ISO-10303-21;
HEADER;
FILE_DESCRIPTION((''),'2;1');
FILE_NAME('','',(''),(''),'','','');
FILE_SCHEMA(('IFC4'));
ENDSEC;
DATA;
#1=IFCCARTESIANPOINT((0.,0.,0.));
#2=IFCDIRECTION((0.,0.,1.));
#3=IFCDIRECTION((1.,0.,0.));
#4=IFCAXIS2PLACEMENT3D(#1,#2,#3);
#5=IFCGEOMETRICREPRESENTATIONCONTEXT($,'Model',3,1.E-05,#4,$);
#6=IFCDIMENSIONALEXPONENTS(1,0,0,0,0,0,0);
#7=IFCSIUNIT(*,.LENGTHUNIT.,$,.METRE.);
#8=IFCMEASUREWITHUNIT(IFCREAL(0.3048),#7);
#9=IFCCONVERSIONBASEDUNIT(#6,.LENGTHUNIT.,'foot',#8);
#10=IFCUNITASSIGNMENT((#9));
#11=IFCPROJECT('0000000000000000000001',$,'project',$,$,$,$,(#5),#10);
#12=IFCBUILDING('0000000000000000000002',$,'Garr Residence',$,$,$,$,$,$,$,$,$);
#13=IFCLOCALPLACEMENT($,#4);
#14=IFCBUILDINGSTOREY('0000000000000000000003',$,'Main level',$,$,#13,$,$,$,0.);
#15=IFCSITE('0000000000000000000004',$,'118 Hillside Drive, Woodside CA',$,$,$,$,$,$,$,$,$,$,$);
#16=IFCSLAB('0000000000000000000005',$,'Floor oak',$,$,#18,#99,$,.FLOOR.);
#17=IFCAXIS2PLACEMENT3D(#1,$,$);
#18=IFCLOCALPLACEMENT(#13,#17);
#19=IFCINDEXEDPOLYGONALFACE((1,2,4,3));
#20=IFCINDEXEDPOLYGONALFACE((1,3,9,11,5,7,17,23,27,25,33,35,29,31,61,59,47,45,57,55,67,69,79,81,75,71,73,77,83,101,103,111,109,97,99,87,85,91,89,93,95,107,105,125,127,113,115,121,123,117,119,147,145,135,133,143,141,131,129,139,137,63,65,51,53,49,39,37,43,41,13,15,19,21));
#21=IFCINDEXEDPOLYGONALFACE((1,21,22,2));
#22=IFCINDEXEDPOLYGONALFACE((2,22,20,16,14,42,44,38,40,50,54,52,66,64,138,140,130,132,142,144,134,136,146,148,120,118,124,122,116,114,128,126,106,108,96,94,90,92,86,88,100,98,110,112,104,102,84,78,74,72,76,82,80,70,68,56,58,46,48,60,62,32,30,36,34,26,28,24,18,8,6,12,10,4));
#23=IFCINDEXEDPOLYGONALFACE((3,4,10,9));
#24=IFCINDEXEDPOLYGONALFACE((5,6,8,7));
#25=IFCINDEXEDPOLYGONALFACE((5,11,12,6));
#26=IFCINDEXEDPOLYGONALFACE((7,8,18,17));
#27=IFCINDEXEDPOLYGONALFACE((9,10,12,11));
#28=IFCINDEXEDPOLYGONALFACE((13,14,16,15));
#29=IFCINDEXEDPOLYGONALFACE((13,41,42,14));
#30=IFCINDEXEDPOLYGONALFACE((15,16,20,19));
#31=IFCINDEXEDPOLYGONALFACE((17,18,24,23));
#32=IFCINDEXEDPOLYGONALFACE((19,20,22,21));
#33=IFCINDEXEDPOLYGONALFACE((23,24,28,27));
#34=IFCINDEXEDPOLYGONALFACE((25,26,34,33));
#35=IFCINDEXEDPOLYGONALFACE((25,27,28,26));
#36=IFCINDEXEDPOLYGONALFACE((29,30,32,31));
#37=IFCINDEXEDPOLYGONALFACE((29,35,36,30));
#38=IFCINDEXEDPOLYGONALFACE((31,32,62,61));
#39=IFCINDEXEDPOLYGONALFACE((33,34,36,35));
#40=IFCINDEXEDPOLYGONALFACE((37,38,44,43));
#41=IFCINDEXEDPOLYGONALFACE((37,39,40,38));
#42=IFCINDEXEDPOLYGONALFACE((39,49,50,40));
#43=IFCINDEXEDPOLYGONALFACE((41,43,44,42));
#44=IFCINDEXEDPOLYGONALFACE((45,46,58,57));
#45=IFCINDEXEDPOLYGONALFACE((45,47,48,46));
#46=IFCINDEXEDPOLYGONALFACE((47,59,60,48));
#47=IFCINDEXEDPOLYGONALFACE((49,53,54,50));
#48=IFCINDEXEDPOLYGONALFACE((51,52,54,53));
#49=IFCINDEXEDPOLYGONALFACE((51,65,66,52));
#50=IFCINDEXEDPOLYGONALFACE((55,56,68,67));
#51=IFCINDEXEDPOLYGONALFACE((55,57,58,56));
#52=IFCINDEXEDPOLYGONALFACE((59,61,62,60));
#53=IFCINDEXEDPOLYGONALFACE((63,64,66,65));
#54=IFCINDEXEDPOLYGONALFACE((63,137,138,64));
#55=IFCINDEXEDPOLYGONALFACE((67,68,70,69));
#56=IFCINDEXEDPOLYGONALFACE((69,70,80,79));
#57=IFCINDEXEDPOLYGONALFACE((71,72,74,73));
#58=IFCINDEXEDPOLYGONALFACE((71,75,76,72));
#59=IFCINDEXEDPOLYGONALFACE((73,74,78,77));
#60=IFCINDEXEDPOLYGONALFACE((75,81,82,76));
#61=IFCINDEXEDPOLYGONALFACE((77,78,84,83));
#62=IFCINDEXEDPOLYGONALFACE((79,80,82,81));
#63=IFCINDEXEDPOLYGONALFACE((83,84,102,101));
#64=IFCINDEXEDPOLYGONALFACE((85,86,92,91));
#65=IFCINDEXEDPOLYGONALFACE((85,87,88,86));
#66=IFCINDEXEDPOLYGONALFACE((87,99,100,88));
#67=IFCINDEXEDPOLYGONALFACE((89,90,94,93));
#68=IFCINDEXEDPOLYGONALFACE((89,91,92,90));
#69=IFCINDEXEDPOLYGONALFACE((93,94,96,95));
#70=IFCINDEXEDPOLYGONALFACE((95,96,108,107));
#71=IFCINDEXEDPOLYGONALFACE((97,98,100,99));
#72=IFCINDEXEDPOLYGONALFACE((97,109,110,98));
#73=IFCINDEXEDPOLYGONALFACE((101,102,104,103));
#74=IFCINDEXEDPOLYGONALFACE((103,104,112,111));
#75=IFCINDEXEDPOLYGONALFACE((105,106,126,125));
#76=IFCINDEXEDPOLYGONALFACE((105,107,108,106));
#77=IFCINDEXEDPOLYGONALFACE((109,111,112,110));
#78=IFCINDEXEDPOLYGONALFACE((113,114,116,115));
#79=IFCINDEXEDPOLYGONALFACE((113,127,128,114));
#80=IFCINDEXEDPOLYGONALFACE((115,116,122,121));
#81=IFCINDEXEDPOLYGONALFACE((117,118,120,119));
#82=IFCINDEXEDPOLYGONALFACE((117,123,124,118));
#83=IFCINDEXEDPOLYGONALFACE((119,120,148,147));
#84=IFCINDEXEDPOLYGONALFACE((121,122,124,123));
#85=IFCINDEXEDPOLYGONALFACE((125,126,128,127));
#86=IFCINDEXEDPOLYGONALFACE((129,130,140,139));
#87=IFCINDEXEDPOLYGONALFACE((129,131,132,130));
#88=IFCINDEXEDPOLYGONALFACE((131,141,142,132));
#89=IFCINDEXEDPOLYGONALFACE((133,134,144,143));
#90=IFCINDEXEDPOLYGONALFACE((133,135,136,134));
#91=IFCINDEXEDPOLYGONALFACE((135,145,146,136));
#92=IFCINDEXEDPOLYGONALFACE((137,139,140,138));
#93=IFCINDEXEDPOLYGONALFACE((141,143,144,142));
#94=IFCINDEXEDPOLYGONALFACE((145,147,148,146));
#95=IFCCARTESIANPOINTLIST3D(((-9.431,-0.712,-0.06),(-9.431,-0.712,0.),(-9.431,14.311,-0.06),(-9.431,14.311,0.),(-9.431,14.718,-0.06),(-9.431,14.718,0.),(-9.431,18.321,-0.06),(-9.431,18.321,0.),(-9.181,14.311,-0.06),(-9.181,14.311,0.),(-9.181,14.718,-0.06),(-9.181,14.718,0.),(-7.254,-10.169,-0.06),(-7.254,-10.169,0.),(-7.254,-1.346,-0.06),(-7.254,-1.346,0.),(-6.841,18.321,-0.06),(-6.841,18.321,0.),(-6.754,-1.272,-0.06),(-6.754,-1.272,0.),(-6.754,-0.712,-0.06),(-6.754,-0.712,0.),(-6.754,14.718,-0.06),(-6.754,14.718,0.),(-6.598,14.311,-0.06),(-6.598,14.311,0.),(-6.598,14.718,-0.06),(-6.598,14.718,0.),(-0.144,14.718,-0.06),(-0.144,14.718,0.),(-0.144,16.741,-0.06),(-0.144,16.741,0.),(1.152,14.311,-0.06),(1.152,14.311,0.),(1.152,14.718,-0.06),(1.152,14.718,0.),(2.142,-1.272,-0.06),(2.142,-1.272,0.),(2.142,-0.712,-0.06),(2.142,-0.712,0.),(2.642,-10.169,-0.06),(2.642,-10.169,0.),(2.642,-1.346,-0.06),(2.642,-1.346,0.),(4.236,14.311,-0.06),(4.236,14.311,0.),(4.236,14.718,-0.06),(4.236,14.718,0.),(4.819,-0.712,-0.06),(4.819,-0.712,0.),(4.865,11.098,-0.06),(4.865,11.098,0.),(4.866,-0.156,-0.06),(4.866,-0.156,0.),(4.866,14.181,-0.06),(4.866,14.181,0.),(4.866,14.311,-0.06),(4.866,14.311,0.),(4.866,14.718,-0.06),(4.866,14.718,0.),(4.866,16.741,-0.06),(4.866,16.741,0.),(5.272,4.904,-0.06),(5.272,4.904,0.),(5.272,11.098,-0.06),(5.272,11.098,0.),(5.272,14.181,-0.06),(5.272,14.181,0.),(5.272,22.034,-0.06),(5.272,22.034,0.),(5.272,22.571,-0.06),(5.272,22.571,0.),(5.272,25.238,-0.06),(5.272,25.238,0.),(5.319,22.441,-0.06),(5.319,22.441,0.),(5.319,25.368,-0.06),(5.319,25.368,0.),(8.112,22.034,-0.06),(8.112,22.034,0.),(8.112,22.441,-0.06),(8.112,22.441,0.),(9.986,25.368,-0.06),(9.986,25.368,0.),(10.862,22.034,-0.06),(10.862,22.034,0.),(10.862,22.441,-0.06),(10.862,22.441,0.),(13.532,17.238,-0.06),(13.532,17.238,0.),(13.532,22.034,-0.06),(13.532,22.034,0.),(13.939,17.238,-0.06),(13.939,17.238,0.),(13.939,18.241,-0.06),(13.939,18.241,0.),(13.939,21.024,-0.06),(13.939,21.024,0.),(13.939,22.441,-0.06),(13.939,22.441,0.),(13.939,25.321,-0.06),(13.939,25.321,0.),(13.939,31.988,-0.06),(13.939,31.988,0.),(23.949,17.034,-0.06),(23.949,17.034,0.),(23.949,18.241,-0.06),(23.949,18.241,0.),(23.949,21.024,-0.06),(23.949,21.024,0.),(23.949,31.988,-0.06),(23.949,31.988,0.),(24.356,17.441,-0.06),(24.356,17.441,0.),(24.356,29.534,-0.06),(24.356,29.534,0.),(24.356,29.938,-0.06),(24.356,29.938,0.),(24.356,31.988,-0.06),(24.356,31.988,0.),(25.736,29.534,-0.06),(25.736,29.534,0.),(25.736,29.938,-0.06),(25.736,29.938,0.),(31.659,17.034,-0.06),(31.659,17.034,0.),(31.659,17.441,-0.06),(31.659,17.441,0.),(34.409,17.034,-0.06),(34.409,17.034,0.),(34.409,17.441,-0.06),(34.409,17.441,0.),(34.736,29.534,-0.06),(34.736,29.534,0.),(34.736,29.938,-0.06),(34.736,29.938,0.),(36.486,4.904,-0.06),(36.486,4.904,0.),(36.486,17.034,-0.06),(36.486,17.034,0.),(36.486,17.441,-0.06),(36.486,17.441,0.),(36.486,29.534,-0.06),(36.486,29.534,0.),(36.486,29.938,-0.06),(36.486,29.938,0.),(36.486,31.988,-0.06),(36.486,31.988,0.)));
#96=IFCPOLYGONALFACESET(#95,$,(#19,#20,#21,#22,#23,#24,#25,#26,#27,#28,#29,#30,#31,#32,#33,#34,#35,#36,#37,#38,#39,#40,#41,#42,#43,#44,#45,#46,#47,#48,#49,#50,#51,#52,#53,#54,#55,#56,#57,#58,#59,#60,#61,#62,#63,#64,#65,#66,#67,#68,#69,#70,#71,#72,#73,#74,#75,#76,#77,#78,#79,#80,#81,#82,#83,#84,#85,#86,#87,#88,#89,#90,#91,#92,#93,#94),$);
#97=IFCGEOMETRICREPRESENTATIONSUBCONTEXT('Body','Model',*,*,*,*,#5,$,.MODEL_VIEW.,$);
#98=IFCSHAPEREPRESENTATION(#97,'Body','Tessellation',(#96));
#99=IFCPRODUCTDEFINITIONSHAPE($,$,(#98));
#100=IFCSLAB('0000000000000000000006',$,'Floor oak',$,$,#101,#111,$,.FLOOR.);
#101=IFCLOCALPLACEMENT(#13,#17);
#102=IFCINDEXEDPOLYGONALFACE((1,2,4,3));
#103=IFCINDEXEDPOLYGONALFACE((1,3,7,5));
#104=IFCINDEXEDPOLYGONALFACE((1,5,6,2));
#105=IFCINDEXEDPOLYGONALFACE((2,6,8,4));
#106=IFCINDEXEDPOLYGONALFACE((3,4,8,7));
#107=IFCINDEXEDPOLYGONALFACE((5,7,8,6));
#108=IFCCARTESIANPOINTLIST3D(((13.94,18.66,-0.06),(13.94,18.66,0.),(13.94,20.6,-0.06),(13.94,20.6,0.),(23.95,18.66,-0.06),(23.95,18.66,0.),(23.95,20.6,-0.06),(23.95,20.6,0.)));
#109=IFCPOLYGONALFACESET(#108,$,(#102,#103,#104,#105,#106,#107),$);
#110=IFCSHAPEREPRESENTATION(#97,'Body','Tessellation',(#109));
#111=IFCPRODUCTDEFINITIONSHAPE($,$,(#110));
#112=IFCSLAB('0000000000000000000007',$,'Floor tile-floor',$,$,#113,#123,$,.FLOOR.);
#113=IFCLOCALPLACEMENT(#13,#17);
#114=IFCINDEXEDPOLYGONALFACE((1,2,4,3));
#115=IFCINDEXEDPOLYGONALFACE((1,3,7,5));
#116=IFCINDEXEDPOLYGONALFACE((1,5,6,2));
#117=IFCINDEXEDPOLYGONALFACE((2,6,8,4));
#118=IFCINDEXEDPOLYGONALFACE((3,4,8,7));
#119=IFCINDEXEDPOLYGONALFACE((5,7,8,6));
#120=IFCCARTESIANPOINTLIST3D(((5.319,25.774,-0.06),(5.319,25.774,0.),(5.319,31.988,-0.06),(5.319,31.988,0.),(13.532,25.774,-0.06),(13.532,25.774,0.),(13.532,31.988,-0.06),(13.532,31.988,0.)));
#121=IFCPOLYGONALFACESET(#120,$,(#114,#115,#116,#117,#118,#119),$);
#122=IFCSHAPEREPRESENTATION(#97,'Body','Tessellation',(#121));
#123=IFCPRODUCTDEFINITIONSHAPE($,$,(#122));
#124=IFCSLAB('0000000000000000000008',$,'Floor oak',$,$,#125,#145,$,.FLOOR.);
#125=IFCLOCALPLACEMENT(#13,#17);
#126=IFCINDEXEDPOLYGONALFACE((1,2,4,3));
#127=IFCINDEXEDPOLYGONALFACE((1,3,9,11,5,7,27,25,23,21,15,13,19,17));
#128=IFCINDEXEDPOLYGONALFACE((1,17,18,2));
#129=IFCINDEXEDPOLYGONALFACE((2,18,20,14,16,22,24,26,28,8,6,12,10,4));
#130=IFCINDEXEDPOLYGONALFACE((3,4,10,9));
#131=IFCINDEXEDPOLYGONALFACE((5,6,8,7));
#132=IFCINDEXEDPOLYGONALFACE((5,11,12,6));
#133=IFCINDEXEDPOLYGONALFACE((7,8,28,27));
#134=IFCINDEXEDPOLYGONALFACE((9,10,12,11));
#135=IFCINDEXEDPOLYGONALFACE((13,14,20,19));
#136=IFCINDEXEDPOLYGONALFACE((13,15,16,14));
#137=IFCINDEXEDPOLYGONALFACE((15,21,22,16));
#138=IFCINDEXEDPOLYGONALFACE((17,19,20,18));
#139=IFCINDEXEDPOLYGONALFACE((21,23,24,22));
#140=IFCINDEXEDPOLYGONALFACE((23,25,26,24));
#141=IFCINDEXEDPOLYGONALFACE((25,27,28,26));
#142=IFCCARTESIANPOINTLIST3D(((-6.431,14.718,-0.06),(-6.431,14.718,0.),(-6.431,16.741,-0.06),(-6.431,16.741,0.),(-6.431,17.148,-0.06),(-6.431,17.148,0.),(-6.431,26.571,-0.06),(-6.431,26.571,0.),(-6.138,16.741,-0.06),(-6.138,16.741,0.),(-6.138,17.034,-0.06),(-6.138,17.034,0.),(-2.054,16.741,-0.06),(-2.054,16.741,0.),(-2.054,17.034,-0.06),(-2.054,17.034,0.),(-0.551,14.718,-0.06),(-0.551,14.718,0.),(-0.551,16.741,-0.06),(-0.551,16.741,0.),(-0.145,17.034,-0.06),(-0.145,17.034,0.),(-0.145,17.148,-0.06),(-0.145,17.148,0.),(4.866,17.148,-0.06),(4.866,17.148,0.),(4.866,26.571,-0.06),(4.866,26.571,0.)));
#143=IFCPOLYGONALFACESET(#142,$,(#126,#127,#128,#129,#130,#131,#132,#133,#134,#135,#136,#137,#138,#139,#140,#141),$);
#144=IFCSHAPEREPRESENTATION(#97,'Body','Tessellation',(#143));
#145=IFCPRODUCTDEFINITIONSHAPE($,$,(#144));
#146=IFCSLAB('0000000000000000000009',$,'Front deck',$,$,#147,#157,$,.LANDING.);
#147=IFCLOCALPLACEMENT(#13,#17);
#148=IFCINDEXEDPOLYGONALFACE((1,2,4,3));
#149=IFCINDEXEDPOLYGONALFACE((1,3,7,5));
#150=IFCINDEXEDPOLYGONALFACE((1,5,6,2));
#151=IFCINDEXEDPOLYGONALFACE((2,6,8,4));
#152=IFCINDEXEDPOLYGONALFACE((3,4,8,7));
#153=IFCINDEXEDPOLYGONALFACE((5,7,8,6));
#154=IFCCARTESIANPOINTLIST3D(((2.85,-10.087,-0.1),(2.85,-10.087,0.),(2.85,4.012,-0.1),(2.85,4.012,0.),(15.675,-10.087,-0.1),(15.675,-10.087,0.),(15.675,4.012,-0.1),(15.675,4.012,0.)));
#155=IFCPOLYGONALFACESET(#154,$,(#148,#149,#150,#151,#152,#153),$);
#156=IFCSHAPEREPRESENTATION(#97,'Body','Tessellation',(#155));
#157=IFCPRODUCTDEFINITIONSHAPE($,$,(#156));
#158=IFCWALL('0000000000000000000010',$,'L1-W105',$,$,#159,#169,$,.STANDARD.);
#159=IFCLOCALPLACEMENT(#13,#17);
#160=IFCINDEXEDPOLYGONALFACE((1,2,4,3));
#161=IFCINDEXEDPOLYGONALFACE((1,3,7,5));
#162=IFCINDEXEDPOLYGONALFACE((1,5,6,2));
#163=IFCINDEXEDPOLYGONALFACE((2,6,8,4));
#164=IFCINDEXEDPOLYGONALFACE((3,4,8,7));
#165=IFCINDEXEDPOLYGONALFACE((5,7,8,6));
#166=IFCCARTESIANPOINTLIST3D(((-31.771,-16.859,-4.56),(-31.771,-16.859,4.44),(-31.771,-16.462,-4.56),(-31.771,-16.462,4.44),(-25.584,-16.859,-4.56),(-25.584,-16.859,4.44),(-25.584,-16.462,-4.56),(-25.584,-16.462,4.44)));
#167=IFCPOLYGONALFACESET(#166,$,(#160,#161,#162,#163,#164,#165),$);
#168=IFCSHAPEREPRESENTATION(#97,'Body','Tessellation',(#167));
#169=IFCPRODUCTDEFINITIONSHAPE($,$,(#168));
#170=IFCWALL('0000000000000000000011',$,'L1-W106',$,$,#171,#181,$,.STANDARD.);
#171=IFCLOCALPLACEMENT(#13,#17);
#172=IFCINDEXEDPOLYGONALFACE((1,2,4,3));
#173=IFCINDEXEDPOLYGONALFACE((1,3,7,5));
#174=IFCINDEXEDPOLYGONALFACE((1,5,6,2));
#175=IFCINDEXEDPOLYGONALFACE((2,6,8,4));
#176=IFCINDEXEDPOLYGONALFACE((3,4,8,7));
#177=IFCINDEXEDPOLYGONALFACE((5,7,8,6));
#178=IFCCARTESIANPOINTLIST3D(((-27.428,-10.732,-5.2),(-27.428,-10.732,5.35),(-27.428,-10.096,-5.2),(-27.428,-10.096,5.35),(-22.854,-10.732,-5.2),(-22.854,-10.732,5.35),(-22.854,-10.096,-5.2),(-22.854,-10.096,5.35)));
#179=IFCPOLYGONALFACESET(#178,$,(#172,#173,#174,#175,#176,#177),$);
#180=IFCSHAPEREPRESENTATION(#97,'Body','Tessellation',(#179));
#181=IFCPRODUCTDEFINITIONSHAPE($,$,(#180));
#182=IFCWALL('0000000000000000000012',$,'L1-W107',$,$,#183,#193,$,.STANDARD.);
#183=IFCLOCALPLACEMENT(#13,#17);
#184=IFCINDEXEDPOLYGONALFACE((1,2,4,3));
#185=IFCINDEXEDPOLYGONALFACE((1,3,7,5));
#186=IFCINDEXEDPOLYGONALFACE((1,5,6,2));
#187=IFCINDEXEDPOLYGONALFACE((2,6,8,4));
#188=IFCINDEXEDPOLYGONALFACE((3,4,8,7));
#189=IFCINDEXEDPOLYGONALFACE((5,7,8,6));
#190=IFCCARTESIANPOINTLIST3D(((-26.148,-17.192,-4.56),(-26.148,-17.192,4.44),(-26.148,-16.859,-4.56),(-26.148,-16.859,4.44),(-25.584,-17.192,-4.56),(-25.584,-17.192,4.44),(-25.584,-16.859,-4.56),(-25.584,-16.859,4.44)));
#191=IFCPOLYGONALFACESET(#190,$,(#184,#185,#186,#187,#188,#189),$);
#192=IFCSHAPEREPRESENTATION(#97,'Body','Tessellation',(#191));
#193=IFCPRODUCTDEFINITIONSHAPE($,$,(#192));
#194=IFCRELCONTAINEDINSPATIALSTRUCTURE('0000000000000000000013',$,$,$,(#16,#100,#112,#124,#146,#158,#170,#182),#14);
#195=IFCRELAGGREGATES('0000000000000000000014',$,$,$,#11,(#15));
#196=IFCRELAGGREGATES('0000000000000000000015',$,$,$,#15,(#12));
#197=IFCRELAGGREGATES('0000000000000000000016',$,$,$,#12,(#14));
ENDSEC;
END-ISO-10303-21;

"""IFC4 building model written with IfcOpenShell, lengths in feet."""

from ifc_helpers import new_model, entity, si_unit, converted_unit, frame, origin, origin_with_axes, place, context, subcontext, project, spatial, polyline, outline, extrude, element, save


model = new_model("IFC4")

# Units and contexts
model_context = context("Model", 3, precision=1e-05, world=origin_with_axes())
body_context = subcontext(model_context, "Body", "Model", "MODEL_VIEW")
ifc_project = project(units=[converted_unit("LENGTHUNIT", "foot", entity("IfcReal", 0.3048), si_unit("LENGTHUNIT", "METRE"), dimensions=[1, 0, 0, 0, 0, 0, 0])], contexts=[model_context])

# Site, building, storey
site = spatial("IfcSite", under=ifc_project, Name="118 Hillside Drive, Woodside CA")
building = spatial("IfcBuilding", under=site, Name="Garr Residence")
storey_placement = place(None, origin_with_axes())
storey = spatial("IfcBuildingStorey", under=building, at=storey_placement, Name="Main level", Elevation=0.0)

# Slabs
slab_1_placement = place(storey_placement, frame((0.0, 0.0, -0.06), z_axis=(0.0, 0.0, 1.0), x_axis=(1.0, 0.0, 0.0)))
element("IfcSlab", 1, at=slab_1_placement, inside=storey, Name="Floor oak", PredefinedType="FLOOR", context=body_context, shape_type="SweptSolid", body=[
    extrude(outline(polyline([(-9.431, 18.321), (-6.841, 18.321), (-6.754, 14.718), (-6.598, 14.718), (-6.598, 14.311), (1.152, 14.311), (1.152, 14.718), (-0.144, 14.718), (-0.144, 16.741), (4.866, 16.741), (4.866, 14.718), (4.236, 14.718), (4.236, 14.311), (4.866, 14.311), (4.866, 14.181), (5.272, 14.181), (5.272, 22.034), (8.112, 22.034), (8.112, 22.441), (5.319, 22.441), (5.272, 22.571), (5.272, 25.238), (5.319, 25.368), (9.986, 25.368), (13.939, 25.321), (13.939, 31.988), (23.949, 31.988), (23.949, 21.024), (13.939, 21.024), (13.939, 22.441), (10.862, 22.441), (10.862, 22.034), (13.532, 22.034), (13.532, 17.238), (13.939, 17.238), (13.939, 18.241), (23.949, 18.241), (23.949, 17.034), (31.659, 17.034), (31.659, 17.441), (24.356, 17.441), (24.356, 29.534), (25.736, 29.534), (25.736, 29.938), (24.356, 29.938), (24.356, 31.988), (36.486, 31.988), (36.486, 29.938), (34.736, 29.938), (34.736, 29.534), (36.486, 29.534), (36.486, 17.441), (34.409, 17.441), (34.409, 17.034), (36.486, 17.034), (36.486, 4.904), (5.272, 4.904), (5.272, 11.098), (4.865, 11.098), (4.866, -0.156), (4.819, -0.712), (2.142, -0.712), (2.142, -1.272), (2.642, -1.346), (2.642, -10.169), (-7.254, -10.169), (-7.254, -1.346), (-6.754, -1.272), (-6.754, -0.712), (-9.431, -0.712), (-9.431, 14.311), (-9.181, 14.311), (-9.181, 14.718), (-9.431, 14.718), (-9.431, 18.321)])), origin(), (0.0, 0.0, 1.0), 0.06),
])
slab_2_placement = place(storey_placement, frame((0.0, 0.0, -0.06), z_axis=(0.0, 0.0, 1.0), x_axis=(1.0, 0.0, 0.0)))
element("IfcSlab", 2, at=slab_2_placement, inside=storey, Name="Floor oak", PredefinedType="FLOOR", context=body_context, shape_type="SweptSolid", body=[
    extrude(outline(polyline([(23.95, 20.6), (23.95, 18.66), (13.94, 18.66), (13.94, 20.6), (23.95, 20.6)])), origin(), (0.0, 0.0, 1.0), 0.06),
])
slab_3_placement = place(storey_placement, frame((0.0, 0.0, -0.06), z_axis=(0.0, 0.0, 1.0), x_axis=(1.0, 0.0, 0.0)))
element("IfcSlab", 3, at=slab_3_placement, inside=storey, Name="Floor tile-floor", PredefinedType="FLOOR", context=body_context, shape_type="SweptSolid", body=[
    extrude(outline(polyline([(5.319, 25.774), (5.319, 31.988), (13.532, 31.988), (13.532, 25.774), (5.319, 25.774)])), origin(), (0.0, 0.0, 1.0), 0.06),
])
slab_4_placement = place(storey_placement, frame((0.0, 0.0, -0.06), z_axis=(0.0, 0.0, 1.0), x_axis=(1.0, 0.0, 0.0)))
element("IfcSlab", 4, at=slab_4_placement, inside=storey, Name="Floor oak", PredefinedType="FLOOR", context=body_context, shape_type="SweptSolid", body=[
    extrude(outline(polyline([(-6.138, 16.741), (-6.138, 17.034), (-6.431, 17.148), (-6.431, 26.571), (4.866, 26.571), (4.866, 17.148), (-0.145, 17.148), (-0.145, 17.034), (-2.054, 17.034), (-2.054, 16.741), (-0.551, 16.741), (-0.551, 14.718), (-6.431, 14.718), (-6.431, 16.741), (-6.138, 16.741)])), origin(), (0.0, 0.0, 1.0), 0.06),
])
slab_5_placement = place(storey_placement, frame((0.0, 0.0, -0.1), z_axis=(0.0, 0.0, 1.0), x_axis=(1.0, 0.0, 0.0)))
element("IfcSlab", 5, at=slab_5_placement, inside=storey, Name="Front deck", PredefinedType="LANDING", context=body_context, shape_type="SweptSolid", body=[
    extrude(outline(polyline([(2.85, -10.087), (15.675, -10.087), (15.675, 4.012), (2.85, 4.012), (2.85, -10.087)])), origin(), (0.0, 0.0, 1.0), 0.1),
])

# Walls
wall_1_placement = place(storey_placement, frame((0.0, 0.0, -4.56), z_axis=(0.0, 0.0, 1.0), x_axis=(1.0, 0.0, 0.0)))
element("IfcWall", 6, at=wall_1_placement, inside=storey, Name="L1-W105", PredefinedType="STANDARD", context=body_context, shape_type="SweptSolid", body=[
    extrude(outline(polyline([(-25.584, -16.859), (-25.584, -16.462), (-31.771, -16.462), (-31.771, -16.859), (-25.584, -16.859)])), origin(), (0.0, 0.0, 1.0), 9.0),
])
wall_2_placement = place(storey_placement, frame((0.0, 0.0, -5.2), z_axis=(0.0, 0.0, 1.0), x_axis=(1.0, 0.0, 0.0)))
element("IfcWall", 7, at=wall_2_placement, inside=storey, Name="L1-W106", PredefinedType="STANDARD", context=body_context, shape_type="SweptSolid", body=[
    extrude(outline(polyline([(-22.854, -10.732), (-22.854, -10.096), (-27.428, -10.096), (-27.428, -10.732), (-22.854, -10.732)])), origin(), (0.0, 0.0, 1.0), 10.55),
])
wall_3_placement = place(storey_placement, frame((0.0, 0.0, -4.56), z_axis=(0.0, 0.0, 1.0), x_axis=(1.0, 0.0, 0.0)))
element("IfcWall", 8, at=wall_3_placement, inside=storey, Name="L1-W107", PredefinedType="STANDARD", context=body_context, shape_type="SweptSolid", body=[
    extrude(outline(polyline([(-25.584, -17.192), (-25.584, -16.859), (-26.148, -16.859), (-26.148, -17.192), (-25.584, -17.192)])), origin(), (0.0, 0.0, 1.0), 9.0),
])

save(model, "model.ifc")
